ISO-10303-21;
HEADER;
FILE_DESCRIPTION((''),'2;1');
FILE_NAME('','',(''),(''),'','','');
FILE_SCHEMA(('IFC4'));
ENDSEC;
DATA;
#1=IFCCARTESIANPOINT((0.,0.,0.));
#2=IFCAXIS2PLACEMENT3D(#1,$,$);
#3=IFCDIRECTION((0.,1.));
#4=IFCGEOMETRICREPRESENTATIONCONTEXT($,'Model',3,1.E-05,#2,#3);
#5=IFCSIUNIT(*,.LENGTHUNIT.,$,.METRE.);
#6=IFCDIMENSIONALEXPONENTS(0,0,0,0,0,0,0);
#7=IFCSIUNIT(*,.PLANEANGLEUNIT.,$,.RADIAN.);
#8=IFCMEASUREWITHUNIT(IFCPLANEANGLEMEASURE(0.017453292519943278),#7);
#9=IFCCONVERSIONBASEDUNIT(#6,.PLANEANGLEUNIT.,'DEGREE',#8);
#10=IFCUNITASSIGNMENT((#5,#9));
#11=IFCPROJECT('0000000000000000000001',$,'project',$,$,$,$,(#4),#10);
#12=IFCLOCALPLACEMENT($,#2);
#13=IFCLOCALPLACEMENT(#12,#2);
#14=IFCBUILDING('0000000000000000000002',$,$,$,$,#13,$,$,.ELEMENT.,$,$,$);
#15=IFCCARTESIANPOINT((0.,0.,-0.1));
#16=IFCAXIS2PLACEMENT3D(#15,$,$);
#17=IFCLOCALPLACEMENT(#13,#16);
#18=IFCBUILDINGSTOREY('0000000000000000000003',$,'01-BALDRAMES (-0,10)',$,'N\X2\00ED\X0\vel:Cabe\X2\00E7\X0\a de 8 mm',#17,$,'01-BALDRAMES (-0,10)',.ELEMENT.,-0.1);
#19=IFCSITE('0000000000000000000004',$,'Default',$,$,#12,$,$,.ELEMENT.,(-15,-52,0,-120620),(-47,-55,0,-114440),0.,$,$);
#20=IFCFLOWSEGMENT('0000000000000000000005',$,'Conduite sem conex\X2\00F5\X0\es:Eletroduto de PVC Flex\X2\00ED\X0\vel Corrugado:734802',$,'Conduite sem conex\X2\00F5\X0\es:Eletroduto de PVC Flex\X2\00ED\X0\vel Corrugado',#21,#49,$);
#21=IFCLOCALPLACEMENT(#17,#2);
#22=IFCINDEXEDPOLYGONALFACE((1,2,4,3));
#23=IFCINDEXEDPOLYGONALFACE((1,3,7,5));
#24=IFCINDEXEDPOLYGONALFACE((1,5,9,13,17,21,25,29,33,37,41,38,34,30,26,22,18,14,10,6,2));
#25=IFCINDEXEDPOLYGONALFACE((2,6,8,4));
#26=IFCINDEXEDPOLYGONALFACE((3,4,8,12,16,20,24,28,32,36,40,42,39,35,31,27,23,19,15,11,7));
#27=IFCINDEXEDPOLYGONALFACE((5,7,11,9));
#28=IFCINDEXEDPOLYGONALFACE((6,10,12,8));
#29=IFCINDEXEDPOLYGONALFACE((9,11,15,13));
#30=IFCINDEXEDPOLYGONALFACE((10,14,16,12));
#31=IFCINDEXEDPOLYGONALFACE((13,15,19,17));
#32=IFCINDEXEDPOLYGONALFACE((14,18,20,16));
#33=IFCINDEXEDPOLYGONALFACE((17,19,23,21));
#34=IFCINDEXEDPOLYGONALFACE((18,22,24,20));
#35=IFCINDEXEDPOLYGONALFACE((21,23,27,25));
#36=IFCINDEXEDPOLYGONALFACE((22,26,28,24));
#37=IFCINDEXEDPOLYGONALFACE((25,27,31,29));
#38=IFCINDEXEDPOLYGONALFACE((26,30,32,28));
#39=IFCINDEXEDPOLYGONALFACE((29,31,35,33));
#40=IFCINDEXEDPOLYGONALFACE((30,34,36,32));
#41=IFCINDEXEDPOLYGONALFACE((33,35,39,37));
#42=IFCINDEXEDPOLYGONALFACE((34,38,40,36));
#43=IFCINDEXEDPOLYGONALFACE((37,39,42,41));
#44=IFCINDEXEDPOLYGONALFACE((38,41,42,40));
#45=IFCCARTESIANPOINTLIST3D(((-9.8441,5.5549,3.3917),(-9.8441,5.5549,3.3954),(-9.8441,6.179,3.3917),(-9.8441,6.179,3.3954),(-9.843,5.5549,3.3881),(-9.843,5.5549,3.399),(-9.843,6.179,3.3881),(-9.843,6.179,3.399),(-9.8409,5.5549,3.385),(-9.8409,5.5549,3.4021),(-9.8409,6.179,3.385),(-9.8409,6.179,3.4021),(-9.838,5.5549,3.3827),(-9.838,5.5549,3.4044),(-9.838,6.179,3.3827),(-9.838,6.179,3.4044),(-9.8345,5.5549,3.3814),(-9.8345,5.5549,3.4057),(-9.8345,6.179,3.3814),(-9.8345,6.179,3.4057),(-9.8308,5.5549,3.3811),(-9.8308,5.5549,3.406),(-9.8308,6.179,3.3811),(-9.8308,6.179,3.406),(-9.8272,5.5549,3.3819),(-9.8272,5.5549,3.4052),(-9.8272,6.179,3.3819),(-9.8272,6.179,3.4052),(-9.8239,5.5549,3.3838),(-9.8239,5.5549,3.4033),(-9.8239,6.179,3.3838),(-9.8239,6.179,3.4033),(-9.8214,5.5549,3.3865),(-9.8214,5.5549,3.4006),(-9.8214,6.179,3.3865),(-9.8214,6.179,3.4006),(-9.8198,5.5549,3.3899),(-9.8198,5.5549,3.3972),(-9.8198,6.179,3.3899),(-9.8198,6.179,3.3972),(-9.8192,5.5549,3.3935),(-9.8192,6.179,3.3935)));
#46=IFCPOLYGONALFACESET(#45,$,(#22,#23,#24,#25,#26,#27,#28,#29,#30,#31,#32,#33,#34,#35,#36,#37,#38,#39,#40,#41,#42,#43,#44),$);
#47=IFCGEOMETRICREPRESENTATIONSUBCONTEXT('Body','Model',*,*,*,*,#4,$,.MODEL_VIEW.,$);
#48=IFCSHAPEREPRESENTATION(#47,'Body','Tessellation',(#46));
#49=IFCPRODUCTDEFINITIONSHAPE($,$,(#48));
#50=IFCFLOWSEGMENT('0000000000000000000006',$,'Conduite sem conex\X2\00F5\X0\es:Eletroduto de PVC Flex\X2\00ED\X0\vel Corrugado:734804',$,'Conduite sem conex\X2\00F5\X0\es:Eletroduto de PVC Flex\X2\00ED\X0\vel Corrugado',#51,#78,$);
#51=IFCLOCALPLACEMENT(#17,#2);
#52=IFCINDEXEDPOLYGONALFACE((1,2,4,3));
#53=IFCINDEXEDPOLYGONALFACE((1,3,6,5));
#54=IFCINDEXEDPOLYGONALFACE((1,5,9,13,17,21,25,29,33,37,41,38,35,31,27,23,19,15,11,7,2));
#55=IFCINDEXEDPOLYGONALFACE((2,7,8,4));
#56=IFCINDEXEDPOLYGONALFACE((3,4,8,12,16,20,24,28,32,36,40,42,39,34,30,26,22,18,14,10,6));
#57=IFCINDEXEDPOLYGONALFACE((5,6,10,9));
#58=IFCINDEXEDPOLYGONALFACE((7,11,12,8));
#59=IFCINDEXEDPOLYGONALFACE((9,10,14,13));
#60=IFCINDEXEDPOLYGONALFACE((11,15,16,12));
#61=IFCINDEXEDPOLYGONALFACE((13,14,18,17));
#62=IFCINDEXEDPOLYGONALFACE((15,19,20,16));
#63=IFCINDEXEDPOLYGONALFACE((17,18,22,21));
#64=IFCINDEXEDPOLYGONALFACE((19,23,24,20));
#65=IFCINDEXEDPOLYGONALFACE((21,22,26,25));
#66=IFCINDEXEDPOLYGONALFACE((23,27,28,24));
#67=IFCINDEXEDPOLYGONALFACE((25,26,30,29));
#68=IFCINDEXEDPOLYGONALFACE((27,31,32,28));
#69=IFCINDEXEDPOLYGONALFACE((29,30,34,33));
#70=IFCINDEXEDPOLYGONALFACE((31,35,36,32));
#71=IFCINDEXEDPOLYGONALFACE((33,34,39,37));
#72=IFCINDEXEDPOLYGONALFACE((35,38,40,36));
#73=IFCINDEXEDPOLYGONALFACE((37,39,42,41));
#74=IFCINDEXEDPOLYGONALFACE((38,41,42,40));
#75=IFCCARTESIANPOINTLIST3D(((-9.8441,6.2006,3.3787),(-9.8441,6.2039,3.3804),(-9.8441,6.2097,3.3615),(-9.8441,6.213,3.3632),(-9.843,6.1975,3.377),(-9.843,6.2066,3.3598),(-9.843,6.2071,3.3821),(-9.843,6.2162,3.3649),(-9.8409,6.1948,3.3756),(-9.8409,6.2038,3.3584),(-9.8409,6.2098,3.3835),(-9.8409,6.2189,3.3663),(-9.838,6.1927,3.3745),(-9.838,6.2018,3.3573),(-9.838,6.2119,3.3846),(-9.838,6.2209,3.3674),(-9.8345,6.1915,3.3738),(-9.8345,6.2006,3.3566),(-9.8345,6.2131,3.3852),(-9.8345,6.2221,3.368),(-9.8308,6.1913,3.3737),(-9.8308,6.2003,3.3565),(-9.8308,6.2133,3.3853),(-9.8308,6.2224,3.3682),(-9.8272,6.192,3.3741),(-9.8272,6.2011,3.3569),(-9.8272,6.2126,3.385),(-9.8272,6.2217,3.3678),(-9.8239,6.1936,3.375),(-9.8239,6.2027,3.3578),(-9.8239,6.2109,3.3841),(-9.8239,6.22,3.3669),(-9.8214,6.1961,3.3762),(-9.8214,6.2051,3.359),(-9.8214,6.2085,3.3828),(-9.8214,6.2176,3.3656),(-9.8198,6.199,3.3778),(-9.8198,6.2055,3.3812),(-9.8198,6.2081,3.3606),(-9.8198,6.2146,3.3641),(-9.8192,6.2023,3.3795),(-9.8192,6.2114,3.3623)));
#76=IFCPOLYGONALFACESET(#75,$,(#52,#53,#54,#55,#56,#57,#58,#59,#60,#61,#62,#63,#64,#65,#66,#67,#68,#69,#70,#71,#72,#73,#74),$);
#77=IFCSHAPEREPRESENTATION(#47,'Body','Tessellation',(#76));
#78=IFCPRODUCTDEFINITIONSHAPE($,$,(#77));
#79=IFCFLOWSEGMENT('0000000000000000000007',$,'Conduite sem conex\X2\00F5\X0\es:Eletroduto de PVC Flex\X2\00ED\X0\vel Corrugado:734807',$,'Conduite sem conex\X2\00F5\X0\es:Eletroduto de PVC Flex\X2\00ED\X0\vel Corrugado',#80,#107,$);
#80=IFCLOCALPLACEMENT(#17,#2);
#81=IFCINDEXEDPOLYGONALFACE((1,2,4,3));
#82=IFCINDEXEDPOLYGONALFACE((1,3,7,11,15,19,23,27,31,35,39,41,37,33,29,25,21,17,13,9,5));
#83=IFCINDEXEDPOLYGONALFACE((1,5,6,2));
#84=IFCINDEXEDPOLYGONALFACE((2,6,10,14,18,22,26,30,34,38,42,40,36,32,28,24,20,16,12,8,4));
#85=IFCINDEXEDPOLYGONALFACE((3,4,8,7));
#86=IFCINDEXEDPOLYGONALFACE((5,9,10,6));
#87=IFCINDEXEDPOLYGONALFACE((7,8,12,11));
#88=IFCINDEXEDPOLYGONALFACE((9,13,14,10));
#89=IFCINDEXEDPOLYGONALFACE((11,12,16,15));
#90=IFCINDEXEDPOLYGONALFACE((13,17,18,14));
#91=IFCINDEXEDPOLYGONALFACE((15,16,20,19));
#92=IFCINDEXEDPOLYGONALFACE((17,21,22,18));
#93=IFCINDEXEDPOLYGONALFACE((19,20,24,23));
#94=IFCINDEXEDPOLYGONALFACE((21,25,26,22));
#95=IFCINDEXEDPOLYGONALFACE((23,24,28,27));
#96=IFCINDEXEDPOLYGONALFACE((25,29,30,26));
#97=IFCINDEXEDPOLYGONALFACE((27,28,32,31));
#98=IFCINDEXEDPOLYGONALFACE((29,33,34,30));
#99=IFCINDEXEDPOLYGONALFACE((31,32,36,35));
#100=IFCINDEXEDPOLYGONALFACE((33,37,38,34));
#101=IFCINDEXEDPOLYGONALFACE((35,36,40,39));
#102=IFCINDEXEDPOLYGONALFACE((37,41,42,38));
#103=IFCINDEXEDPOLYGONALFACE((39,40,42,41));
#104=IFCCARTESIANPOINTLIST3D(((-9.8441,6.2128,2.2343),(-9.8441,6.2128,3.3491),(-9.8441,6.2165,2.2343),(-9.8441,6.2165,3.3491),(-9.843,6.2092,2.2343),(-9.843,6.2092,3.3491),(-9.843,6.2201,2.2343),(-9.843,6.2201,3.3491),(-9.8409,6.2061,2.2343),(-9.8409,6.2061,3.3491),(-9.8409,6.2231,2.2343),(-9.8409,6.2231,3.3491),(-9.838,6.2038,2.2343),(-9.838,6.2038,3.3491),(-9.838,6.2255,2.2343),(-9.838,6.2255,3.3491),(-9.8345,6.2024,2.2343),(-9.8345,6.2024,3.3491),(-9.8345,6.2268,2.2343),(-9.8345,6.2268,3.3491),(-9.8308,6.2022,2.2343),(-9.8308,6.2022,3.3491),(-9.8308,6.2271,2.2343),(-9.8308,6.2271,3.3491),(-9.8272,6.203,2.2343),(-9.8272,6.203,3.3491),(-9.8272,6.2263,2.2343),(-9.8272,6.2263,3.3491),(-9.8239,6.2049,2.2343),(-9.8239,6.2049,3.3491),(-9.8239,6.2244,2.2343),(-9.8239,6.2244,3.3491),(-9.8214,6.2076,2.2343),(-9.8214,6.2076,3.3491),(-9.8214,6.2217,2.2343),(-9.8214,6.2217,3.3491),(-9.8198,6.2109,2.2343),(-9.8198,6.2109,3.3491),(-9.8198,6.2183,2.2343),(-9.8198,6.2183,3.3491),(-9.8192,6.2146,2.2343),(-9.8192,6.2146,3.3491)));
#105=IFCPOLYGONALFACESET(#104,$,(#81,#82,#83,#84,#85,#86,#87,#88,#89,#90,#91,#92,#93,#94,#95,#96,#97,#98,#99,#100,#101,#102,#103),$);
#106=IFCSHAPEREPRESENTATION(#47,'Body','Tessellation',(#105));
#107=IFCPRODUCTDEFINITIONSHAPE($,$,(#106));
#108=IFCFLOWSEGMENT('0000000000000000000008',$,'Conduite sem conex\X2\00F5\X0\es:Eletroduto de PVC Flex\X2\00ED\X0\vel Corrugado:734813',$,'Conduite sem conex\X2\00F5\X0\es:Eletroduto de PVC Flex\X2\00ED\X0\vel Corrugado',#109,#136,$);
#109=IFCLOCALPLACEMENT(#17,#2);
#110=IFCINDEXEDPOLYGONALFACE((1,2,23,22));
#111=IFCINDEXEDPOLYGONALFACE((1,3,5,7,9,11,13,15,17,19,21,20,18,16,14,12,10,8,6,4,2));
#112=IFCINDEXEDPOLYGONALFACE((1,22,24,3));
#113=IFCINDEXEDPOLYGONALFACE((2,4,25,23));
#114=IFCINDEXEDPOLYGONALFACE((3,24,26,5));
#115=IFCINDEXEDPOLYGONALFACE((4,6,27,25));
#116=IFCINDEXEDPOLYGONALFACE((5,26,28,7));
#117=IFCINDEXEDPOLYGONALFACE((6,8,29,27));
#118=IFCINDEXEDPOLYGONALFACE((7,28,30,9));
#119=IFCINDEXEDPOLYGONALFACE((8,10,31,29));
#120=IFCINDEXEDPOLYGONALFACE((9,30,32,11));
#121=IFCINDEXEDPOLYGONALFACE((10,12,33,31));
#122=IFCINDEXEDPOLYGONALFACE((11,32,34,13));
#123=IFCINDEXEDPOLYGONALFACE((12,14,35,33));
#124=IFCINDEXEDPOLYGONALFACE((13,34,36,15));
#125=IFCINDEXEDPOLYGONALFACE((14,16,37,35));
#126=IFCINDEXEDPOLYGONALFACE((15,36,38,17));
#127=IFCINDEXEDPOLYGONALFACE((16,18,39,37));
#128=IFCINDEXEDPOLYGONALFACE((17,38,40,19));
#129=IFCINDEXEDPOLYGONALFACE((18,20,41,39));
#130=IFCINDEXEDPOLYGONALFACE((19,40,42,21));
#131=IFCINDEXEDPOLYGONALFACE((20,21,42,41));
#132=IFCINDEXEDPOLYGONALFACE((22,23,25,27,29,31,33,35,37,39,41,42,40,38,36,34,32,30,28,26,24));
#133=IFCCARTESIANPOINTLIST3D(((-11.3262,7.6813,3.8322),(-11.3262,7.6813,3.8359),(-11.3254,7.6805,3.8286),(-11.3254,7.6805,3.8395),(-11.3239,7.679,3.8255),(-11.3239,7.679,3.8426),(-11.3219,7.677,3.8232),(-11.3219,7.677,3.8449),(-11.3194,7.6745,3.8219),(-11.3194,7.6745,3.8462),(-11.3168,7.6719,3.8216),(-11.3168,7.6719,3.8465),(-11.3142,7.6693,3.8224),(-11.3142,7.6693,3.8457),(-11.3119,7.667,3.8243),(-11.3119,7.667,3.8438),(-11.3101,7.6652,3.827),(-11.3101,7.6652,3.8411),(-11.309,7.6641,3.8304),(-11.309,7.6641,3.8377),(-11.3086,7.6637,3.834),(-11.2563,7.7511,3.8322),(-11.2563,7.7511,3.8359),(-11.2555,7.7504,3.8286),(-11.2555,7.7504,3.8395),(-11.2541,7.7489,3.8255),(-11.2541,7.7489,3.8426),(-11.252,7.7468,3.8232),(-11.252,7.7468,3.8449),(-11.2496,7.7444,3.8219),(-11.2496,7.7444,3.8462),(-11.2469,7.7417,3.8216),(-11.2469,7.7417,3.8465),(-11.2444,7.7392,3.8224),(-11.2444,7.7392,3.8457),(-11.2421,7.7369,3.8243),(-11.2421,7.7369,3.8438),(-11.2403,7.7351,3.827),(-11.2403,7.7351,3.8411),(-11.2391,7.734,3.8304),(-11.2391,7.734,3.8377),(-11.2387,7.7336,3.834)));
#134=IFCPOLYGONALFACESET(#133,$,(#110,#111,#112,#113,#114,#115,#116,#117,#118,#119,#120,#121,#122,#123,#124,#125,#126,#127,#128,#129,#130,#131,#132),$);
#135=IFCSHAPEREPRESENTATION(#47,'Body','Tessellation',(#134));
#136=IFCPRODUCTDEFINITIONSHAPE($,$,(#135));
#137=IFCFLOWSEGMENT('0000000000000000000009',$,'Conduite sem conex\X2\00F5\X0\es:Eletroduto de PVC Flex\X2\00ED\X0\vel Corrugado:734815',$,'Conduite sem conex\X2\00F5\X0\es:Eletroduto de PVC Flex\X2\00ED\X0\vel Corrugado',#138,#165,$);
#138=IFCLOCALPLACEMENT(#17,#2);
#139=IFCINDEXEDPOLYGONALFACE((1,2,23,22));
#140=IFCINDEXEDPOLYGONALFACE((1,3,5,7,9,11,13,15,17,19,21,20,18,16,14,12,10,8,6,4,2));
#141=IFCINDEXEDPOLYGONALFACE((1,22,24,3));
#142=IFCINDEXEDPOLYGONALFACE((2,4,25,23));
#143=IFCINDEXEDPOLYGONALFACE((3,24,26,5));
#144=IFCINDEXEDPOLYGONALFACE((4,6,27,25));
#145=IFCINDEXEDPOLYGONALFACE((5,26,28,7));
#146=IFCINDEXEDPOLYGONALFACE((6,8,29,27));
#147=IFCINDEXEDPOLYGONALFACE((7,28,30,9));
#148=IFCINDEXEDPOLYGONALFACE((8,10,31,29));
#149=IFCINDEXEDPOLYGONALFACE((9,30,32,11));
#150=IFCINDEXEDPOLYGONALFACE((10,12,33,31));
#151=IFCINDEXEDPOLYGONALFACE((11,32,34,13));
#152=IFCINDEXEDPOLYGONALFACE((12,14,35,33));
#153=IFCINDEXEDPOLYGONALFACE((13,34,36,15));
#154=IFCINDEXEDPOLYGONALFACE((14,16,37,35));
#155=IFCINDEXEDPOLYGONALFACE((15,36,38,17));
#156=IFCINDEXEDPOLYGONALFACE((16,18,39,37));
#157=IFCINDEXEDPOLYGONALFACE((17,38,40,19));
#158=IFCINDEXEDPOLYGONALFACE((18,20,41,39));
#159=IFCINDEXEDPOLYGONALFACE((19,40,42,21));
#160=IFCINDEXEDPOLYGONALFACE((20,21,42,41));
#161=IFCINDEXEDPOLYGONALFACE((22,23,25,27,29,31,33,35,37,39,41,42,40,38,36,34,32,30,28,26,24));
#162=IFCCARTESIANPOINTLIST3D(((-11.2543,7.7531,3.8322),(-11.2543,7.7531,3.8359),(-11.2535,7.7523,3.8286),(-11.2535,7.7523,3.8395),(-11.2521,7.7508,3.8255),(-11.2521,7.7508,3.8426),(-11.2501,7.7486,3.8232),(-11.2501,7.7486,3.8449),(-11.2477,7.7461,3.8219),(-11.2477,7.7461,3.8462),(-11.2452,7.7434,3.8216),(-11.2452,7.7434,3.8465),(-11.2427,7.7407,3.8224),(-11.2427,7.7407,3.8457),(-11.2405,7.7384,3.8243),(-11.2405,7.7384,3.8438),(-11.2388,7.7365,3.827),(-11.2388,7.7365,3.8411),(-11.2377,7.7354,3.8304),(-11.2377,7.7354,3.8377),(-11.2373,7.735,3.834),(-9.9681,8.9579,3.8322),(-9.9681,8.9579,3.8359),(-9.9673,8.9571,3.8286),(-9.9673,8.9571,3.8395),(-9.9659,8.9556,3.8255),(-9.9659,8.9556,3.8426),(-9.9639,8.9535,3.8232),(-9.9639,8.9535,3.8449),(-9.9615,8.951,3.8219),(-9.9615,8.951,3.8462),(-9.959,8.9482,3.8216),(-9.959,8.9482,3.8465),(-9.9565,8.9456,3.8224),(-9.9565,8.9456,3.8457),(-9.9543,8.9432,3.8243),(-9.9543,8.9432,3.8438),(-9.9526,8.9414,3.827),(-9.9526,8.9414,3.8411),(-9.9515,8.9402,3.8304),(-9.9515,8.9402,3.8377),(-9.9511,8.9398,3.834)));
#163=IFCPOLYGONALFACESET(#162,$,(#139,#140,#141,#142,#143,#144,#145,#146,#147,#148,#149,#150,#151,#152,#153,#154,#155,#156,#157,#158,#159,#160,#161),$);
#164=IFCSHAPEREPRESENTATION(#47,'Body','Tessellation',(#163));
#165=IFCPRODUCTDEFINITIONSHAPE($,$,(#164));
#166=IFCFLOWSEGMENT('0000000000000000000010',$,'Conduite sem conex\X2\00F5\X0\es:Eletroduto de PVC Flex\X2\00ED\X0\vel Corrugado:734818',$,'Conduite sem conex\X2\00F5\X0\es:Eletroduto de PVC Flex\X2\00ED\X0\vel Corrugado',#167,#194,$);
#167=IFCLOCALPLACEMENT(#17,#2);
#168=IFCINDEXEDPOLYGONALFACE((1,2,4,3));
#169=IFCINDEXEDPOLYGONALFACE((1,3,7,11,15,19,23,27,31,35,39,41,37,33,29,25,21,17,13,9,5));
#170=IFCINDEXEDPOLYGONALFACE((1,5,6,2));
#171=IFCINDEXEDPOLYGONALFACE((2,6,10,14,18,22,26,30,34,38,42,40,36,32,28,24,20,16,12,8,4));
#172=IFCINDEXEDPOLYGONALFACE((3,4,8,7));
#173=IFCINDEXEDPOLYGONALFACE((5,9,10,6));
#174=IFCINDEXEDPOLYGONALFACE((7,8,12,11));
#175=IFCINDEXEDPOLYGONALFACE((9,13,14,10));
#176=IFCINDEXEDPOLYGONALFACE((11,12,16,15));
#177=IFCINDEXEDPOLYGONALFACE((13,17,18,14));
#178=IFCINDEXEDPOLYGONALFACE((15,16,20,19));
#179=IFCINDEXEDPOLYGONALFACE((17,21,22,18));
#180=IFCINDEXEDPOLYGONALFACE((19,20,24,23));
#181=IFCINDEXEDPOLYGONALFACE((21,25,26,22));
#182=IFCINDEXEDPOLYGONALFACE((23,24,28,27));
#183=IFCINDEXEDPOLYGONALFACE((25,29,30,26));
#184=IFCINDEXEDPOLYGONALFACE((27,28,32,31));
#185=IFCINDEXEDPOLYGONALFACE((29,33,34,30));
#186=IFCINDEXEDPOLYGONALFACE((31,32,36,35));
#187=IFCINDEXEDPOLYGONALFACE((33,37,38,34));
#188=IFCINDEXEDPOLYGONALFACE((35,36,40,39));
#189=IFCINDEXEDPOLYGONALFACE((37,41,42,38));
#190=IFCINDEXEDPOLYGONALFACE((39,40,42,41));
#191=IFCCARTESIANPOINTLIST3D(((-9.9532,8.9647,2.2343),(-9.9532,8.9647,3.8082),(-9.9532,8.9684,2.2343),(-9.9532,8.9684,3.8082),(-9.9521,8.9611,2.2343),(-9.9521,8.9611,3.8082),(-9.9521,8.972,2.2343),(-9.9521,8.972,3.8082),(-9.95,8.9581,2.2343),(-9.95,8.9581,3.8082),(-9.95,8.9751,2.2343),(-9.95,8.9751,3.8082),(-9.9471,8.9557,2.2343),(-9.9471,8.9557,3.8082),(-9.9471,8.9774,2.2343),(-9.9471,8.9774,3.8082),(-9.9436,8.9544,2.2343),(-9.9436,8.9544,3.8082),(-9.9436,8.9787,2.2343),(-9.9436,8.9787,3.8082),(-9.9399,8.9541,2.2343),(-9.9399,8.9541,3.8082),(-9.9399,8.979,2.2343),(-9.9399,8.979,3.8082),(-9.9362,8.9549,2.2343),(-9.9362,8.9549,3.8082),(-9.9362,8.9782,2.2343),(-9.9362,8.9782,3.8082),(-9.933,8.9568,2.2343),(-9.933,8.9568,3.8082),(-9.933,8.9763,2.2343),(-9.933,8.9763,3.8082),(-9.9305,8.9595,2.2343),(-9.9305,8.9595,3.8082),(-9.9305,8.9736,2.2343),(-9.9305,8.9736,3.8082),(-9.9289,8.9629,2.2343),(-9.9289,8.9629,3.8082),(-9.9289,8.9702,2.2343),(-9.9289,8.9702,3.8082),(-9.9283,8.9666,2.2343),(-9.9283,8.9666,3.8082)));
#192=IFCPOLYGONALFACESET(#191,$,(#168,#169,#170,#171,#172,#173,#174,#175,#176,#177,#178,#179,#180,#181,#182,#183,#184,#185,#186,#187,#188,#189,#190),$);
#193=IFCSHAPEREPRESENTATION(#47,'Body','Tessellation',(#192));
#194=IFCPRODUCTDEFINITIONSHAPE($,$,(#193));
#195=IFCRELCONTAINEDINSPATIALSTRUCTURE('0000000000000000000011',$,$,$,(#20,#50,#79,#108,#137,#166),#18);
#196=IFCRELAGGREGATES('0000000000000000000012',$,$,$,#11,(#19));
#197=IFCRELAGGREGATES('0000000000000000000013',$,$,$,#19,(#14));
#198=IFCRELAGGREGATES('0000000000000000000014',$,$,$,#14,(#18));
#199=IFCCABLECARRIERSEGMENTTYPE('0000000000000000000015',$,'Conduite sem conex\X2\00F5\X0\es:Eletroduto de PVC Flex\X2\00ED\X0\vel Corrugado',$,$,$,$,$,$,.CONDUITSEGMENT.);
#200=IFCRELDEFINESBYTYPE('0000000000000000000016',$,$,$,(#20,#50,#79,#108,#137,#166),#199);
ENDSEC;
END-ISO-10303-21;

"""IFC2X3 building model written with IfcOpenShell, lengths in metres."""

from ifc_helpers import new_model, entity, si_unit, converted_unit, direction, frame, frame_2d, origin, origin_2d_with_axis, place, context, subcontext, project, spatial, circle, extrude, type_object, element, save


model = new_model("IFC2X3")

# Units and contexts
model_context = context("Model", 3, precision=1e-05, world=origin(), true_north=direction((0.0, 1.0)))
body_context = subcontext(model_context, "Body", "Model", "MODEL_VIEW")
ifc_project = project(units=[si_unit("LENGTHUNIT", "METRE"), converted_unit("PLANEANGLEUNIT", "DEGREE", entity("IfcPlaneAngleMeasure", 0.017453292519943278), si_unit("PLANEANGLEUNIT", "RADIAN"), dimensions=[0, 0, 0, 0, 0, 0, 0])], contexts=[model_context])

# Site, building, storey
site_placement = place(None, origin())
site = spatial("IfcSite", under=ifc_project, at=site_placement, Name="Default", CompositionType="ELEMENT", RefLatitude=(-15, -52, 0, -120620), RefLongitude=(-47, -55, 0, -114440), RefElevation=0.0)
building_placement = place(site_placement, origin())
building = spatial("IfcBuilding", under=site, at=building_placement, CompositionType="ELEMENT")
storey_placement = place(building_placement, frame((0.0, 0.0, -0.1)))
storey = spatial("IfcBuildingStorey", under=building, at=storey_placement, Name="01-BALDRAMES (-0,10)", ObjectType="Nível:Cabeça de 8 mm", LongName="01-BALDRAMES (-0,10)", CompositionType="ELEMENT", Elevation=-0.1)

# Flow segments
cable_carrier_segment_type = type_object("IfcCableCarrierSegmentType", Name="Conduite sem conexões:Eletroduto de PVC Flexível Corrugado", PredefinedType="CONDUITSEGMENT")
flow_segment_1_placement = place(storey_placement, origin())
element("IfcFlowSegment", 1, at=flow_segment_1_placement, inside=storey, type_object=cable_carrier_segment_type, Name="Conduite sem conexões:Eletroduto de PVC Flexível Corrugado:734802", ObjectType="Conduite sem conexões:Eletroduto de PVC Flexível Corrugado", context=body_context, shape_type="SweptSolid", body=[
    extrude(circle(Radius=0.0125, at=frame_2d((0.0, 0.0), x_axis=(1.0, 0.0))), frame((-9.8317, 5.5549, 3.3935), z_axis=(0.0, 1.0, 0.0), x_axis=(1.0, 0.0, 0.0)), (0.0, 0.0, 1.0), 0.6241),
])
flow_segment_2_placement = place(storey_placement, origin())
element("IfcFlowSegment", 2, at=flow_segment_2_placement, inside=storey, type_object=cable_carrier_segment_type, Name="Conduite sem conexões:Eletroduto de PVC Flexível Corrugado:734804", ObjectType="Conduite sem conexões:Eletroduto de PVC Flexível Corrugado", context=body_context, shape_type="SweptSolid", body=[
    extrude(circle(Radius=0.0125, at=origin_2d_with_axis()), frame((-9.8317, 6.2023, 3.3795), z_axis=(0.0, 0.467228, -0.884137), x_axis=(1.0, 0.0, 0.0)), (0.0, 0.0, 1.0), 0.0194),
])
flow_segment_3_placement = place(storey_placement, origin())
element("IfcFlowSegment", 3, at=flow_segment_3_placement, inside=storey, type_object=cable_carrier_segment_type, Name="Conduite sem conexões:Eletroduto de PVC Flexível Corrugado:734807", ObjectType="Conduite sem conexões:Eletroduto de PVC Flexível Corrugado", context=body_context, shape_type="SweptSolid", body=[
    extrude(circle(Radius=0.0125, at=origin_2d_with_axis()), frame((-9.8317, 6.2146, 2.2343)), (0.0, 0.0, 1.0), 1.1148),
])
flow_segment_4_placement = place(storey_placement, origin())
element("IfcFlowSegment", 4, at=flow_segment_4_placement, inside=storey, type_object=cable_carrier_segment_type, Name="Conduite sem conexões:Eletroduto de PVC Flexível Corrugado:734813", ObjectType="Conduite sem conexões:Eletroduto de PVC Flexível Corrugado", context=body_context, shape_type="SweptSolid", body=[
    extrude(circle(Radius=0.0125, at=origin_2d_with_axis()), frame((-11.3174, 7.6725, 3.834), z_axis=(0.707107, 0.707107, 0.0), x_axis=(0.707107, -0.707107, 0.0)), (0.0, 0.0, 1.0), 0.0988),
])
flow_segment_5_placement = place(storey_placement, origin())
element("IfcFlowSegment", 5, at=flow_segment_5_placement, inside=storey, type_object=cable_carrier_segment_type, Name="Conduite sem conexões:Eletroduto de PVC Flexível Corrugado:734815", ObjectType="Conduite sem conexões:Eletroduto de PVC Flexível Corrugado", context=body_context, shape_type="SweptSolid", body=[
    extrude(circle(Radius=0.0125, at=origin_2d_with_axis()), frame((-11.2458, 7.7441, 3.834), z_axis=(0.729814, 0.683646, 0.0), x_axis=(0.683646, -0.729814, 0.0)), (0.0, 0.0, 1.0), 1.7624),
])
flow_segment_6_placement = place(storey_placement, origin())
element("IfcFlowSegment", 6, at=flow_segment_6_placement, inside=storey, type_object=cable_carrier_segment_type, Name="Conduite sem conexões:Eletroduto de PVC Flexível Corrugado:734818", ObjectType="Conduite sem conexões:Eletroduto de PVC Flexível Corrugado", context=body_context, shape_type="SweptSolid", body=[
    extrude(circle(Radius=0.0125, at=frame_2d((0.0, 0.0), x_axis=(1.0, 0.0))), frame((-9.9408, 8.9666, 2.2343)), (0.0, 0.0, 1.0), 1.574),
])

save(model, "model.ifc")
